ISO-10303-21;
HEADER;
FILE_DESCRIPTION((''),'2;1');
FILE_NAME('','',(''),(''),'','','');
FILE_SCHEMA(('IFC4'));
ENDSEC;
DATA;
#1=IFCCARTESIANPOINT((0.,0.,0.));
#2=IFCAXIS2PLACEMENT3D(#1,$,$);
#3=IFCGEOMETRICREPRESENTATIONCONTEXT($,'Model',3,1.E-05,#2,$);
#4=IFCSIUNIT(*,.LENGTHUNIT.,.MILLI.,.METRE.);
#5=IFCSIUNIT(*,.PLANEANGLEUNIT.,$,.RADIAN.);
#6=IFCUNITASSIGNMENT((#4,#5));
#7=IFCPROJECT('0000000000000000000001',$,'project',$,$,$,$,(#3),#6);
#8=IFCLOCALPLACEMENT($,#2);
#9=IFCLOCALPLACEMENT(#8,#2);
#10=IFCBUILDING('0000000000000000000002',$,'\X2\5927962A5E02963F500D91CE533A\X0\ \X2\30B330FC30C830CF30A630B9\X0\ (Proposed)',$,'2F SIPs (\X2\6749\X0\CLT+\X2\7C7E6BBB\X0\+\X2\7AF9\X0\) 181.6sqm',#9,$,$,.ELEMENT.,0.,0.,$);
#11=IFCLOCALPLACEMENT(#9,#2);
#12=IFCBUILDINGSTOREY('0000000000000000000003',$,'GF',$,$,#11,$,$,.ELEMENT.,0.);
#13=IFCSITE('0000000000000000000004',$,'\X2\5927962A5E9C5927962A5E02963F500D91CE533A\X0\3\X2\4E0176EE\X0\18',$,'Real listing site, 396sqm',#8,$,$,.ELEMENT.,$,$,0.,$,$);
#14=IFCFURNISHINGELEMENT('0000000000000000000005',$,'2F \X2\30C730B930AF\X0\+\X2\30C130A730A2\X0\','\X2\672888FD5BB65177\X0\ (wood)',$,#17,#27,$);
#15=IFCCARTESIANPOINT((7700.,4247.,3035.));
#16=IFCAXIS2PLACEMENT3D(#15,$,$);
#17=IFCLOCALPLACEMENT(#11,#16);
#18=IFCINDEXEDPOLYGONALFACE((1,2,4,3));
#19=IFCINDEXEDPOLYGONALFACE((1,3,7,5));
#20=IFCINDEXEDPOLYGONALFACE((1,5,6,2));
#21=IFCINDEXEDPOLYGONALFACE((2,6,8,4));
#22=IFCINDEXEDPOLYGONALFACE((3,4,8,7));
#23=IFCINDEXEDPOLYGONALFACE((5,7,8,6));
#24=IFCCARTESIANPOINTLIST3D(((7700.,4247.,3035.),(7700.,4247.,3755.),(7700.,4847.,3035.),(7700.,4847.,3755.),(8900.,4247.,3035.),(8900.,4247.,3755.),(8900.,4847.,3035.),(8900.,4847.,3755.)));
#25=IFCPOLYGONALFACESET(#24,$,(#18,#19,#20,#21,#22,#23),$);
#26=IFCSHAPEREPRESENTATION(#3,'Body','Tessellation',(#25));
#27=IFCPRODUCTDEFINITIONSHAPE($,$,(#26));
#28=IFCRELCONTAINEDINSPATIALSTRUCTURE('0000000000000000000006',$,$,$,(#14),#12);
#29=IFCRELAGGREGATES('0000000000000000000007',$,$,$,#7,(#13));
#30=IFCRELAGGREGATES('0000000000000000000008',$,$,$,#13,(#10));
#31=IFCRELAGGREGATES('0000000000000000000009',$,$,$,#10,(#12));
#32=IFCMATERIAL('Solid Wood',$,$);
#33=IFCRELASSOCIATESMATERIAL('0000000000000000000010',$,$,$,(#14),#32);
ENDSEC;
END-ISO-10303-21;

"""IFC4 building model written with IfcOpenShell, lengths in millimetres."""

from ifc_helpers import new_model, si_unit, frame, frame_2d, origin, place, context, project, spatial, rectangle, extrude, material, element, save


model = new_model("IFC4")

# Units and contexts
model_context = context("Model", 3, precision=1e-05, world=origin())
ifc_project = project(units=[si_unit("LENGTHUNIT", "METRE", prefix="MILLI"), si_unit("PLANEANGLEUNIT", "RADIAN")], contexts=[model_context])

# Site, building, storey
site_placement = place(None, origin())
site = spatial("IfcSite", under=ifc_project, at=site_placement, Name="大阪府大阪市阿倍野区3丁目18", ObjectType="Real listing site, 396sqm", CompositionType="ELEMENT", RefElevation=0.0)
building_placement = place(site_placement, origin())
building = spatial("IfcBuilding", under=site, at=building_placement, Name="大阪市阿倍野区 コートハウス (Proposed)", ObjectType="2F SIPs (杉CLT+籾殻+竹) 181.6sqm", CompositionType="ELEMENT", ElevationOfRefHeight=0.0, ElevationOfTerrain=0.0)
storey_placement = place(building_placement, origin())
storey = spatial("IfcBuildingStorey", under=building, at=storey_placement, Name="GF", CompositionType="ELEMENT", Elevation=0.0)

# Shared definitions
ifc_material_1 = material(Name="Solid Wood")

# Furnishing element
furnishing_1_placement = place(storey_placement, frame((7700.0, 4247.0, 3035.0)))
element("IfcFurnishingElement", 1, at=furnishing_1_placement, inside=storey, material=ifc_material_1, Name="2F デスク+チェア", Description="木製家具 (wood)", context=model_context, shape_type="SweptSolid", body=[
    extrude(rectangle(XDim=1200.0, YDim=600.0, at=frame_2d((600.0, 300.0))), frame((7700.0, 4247.0, 3035.0)), (0.0, 0.0, 1.0), 720.0),
])

save(model, "model.ifc")
